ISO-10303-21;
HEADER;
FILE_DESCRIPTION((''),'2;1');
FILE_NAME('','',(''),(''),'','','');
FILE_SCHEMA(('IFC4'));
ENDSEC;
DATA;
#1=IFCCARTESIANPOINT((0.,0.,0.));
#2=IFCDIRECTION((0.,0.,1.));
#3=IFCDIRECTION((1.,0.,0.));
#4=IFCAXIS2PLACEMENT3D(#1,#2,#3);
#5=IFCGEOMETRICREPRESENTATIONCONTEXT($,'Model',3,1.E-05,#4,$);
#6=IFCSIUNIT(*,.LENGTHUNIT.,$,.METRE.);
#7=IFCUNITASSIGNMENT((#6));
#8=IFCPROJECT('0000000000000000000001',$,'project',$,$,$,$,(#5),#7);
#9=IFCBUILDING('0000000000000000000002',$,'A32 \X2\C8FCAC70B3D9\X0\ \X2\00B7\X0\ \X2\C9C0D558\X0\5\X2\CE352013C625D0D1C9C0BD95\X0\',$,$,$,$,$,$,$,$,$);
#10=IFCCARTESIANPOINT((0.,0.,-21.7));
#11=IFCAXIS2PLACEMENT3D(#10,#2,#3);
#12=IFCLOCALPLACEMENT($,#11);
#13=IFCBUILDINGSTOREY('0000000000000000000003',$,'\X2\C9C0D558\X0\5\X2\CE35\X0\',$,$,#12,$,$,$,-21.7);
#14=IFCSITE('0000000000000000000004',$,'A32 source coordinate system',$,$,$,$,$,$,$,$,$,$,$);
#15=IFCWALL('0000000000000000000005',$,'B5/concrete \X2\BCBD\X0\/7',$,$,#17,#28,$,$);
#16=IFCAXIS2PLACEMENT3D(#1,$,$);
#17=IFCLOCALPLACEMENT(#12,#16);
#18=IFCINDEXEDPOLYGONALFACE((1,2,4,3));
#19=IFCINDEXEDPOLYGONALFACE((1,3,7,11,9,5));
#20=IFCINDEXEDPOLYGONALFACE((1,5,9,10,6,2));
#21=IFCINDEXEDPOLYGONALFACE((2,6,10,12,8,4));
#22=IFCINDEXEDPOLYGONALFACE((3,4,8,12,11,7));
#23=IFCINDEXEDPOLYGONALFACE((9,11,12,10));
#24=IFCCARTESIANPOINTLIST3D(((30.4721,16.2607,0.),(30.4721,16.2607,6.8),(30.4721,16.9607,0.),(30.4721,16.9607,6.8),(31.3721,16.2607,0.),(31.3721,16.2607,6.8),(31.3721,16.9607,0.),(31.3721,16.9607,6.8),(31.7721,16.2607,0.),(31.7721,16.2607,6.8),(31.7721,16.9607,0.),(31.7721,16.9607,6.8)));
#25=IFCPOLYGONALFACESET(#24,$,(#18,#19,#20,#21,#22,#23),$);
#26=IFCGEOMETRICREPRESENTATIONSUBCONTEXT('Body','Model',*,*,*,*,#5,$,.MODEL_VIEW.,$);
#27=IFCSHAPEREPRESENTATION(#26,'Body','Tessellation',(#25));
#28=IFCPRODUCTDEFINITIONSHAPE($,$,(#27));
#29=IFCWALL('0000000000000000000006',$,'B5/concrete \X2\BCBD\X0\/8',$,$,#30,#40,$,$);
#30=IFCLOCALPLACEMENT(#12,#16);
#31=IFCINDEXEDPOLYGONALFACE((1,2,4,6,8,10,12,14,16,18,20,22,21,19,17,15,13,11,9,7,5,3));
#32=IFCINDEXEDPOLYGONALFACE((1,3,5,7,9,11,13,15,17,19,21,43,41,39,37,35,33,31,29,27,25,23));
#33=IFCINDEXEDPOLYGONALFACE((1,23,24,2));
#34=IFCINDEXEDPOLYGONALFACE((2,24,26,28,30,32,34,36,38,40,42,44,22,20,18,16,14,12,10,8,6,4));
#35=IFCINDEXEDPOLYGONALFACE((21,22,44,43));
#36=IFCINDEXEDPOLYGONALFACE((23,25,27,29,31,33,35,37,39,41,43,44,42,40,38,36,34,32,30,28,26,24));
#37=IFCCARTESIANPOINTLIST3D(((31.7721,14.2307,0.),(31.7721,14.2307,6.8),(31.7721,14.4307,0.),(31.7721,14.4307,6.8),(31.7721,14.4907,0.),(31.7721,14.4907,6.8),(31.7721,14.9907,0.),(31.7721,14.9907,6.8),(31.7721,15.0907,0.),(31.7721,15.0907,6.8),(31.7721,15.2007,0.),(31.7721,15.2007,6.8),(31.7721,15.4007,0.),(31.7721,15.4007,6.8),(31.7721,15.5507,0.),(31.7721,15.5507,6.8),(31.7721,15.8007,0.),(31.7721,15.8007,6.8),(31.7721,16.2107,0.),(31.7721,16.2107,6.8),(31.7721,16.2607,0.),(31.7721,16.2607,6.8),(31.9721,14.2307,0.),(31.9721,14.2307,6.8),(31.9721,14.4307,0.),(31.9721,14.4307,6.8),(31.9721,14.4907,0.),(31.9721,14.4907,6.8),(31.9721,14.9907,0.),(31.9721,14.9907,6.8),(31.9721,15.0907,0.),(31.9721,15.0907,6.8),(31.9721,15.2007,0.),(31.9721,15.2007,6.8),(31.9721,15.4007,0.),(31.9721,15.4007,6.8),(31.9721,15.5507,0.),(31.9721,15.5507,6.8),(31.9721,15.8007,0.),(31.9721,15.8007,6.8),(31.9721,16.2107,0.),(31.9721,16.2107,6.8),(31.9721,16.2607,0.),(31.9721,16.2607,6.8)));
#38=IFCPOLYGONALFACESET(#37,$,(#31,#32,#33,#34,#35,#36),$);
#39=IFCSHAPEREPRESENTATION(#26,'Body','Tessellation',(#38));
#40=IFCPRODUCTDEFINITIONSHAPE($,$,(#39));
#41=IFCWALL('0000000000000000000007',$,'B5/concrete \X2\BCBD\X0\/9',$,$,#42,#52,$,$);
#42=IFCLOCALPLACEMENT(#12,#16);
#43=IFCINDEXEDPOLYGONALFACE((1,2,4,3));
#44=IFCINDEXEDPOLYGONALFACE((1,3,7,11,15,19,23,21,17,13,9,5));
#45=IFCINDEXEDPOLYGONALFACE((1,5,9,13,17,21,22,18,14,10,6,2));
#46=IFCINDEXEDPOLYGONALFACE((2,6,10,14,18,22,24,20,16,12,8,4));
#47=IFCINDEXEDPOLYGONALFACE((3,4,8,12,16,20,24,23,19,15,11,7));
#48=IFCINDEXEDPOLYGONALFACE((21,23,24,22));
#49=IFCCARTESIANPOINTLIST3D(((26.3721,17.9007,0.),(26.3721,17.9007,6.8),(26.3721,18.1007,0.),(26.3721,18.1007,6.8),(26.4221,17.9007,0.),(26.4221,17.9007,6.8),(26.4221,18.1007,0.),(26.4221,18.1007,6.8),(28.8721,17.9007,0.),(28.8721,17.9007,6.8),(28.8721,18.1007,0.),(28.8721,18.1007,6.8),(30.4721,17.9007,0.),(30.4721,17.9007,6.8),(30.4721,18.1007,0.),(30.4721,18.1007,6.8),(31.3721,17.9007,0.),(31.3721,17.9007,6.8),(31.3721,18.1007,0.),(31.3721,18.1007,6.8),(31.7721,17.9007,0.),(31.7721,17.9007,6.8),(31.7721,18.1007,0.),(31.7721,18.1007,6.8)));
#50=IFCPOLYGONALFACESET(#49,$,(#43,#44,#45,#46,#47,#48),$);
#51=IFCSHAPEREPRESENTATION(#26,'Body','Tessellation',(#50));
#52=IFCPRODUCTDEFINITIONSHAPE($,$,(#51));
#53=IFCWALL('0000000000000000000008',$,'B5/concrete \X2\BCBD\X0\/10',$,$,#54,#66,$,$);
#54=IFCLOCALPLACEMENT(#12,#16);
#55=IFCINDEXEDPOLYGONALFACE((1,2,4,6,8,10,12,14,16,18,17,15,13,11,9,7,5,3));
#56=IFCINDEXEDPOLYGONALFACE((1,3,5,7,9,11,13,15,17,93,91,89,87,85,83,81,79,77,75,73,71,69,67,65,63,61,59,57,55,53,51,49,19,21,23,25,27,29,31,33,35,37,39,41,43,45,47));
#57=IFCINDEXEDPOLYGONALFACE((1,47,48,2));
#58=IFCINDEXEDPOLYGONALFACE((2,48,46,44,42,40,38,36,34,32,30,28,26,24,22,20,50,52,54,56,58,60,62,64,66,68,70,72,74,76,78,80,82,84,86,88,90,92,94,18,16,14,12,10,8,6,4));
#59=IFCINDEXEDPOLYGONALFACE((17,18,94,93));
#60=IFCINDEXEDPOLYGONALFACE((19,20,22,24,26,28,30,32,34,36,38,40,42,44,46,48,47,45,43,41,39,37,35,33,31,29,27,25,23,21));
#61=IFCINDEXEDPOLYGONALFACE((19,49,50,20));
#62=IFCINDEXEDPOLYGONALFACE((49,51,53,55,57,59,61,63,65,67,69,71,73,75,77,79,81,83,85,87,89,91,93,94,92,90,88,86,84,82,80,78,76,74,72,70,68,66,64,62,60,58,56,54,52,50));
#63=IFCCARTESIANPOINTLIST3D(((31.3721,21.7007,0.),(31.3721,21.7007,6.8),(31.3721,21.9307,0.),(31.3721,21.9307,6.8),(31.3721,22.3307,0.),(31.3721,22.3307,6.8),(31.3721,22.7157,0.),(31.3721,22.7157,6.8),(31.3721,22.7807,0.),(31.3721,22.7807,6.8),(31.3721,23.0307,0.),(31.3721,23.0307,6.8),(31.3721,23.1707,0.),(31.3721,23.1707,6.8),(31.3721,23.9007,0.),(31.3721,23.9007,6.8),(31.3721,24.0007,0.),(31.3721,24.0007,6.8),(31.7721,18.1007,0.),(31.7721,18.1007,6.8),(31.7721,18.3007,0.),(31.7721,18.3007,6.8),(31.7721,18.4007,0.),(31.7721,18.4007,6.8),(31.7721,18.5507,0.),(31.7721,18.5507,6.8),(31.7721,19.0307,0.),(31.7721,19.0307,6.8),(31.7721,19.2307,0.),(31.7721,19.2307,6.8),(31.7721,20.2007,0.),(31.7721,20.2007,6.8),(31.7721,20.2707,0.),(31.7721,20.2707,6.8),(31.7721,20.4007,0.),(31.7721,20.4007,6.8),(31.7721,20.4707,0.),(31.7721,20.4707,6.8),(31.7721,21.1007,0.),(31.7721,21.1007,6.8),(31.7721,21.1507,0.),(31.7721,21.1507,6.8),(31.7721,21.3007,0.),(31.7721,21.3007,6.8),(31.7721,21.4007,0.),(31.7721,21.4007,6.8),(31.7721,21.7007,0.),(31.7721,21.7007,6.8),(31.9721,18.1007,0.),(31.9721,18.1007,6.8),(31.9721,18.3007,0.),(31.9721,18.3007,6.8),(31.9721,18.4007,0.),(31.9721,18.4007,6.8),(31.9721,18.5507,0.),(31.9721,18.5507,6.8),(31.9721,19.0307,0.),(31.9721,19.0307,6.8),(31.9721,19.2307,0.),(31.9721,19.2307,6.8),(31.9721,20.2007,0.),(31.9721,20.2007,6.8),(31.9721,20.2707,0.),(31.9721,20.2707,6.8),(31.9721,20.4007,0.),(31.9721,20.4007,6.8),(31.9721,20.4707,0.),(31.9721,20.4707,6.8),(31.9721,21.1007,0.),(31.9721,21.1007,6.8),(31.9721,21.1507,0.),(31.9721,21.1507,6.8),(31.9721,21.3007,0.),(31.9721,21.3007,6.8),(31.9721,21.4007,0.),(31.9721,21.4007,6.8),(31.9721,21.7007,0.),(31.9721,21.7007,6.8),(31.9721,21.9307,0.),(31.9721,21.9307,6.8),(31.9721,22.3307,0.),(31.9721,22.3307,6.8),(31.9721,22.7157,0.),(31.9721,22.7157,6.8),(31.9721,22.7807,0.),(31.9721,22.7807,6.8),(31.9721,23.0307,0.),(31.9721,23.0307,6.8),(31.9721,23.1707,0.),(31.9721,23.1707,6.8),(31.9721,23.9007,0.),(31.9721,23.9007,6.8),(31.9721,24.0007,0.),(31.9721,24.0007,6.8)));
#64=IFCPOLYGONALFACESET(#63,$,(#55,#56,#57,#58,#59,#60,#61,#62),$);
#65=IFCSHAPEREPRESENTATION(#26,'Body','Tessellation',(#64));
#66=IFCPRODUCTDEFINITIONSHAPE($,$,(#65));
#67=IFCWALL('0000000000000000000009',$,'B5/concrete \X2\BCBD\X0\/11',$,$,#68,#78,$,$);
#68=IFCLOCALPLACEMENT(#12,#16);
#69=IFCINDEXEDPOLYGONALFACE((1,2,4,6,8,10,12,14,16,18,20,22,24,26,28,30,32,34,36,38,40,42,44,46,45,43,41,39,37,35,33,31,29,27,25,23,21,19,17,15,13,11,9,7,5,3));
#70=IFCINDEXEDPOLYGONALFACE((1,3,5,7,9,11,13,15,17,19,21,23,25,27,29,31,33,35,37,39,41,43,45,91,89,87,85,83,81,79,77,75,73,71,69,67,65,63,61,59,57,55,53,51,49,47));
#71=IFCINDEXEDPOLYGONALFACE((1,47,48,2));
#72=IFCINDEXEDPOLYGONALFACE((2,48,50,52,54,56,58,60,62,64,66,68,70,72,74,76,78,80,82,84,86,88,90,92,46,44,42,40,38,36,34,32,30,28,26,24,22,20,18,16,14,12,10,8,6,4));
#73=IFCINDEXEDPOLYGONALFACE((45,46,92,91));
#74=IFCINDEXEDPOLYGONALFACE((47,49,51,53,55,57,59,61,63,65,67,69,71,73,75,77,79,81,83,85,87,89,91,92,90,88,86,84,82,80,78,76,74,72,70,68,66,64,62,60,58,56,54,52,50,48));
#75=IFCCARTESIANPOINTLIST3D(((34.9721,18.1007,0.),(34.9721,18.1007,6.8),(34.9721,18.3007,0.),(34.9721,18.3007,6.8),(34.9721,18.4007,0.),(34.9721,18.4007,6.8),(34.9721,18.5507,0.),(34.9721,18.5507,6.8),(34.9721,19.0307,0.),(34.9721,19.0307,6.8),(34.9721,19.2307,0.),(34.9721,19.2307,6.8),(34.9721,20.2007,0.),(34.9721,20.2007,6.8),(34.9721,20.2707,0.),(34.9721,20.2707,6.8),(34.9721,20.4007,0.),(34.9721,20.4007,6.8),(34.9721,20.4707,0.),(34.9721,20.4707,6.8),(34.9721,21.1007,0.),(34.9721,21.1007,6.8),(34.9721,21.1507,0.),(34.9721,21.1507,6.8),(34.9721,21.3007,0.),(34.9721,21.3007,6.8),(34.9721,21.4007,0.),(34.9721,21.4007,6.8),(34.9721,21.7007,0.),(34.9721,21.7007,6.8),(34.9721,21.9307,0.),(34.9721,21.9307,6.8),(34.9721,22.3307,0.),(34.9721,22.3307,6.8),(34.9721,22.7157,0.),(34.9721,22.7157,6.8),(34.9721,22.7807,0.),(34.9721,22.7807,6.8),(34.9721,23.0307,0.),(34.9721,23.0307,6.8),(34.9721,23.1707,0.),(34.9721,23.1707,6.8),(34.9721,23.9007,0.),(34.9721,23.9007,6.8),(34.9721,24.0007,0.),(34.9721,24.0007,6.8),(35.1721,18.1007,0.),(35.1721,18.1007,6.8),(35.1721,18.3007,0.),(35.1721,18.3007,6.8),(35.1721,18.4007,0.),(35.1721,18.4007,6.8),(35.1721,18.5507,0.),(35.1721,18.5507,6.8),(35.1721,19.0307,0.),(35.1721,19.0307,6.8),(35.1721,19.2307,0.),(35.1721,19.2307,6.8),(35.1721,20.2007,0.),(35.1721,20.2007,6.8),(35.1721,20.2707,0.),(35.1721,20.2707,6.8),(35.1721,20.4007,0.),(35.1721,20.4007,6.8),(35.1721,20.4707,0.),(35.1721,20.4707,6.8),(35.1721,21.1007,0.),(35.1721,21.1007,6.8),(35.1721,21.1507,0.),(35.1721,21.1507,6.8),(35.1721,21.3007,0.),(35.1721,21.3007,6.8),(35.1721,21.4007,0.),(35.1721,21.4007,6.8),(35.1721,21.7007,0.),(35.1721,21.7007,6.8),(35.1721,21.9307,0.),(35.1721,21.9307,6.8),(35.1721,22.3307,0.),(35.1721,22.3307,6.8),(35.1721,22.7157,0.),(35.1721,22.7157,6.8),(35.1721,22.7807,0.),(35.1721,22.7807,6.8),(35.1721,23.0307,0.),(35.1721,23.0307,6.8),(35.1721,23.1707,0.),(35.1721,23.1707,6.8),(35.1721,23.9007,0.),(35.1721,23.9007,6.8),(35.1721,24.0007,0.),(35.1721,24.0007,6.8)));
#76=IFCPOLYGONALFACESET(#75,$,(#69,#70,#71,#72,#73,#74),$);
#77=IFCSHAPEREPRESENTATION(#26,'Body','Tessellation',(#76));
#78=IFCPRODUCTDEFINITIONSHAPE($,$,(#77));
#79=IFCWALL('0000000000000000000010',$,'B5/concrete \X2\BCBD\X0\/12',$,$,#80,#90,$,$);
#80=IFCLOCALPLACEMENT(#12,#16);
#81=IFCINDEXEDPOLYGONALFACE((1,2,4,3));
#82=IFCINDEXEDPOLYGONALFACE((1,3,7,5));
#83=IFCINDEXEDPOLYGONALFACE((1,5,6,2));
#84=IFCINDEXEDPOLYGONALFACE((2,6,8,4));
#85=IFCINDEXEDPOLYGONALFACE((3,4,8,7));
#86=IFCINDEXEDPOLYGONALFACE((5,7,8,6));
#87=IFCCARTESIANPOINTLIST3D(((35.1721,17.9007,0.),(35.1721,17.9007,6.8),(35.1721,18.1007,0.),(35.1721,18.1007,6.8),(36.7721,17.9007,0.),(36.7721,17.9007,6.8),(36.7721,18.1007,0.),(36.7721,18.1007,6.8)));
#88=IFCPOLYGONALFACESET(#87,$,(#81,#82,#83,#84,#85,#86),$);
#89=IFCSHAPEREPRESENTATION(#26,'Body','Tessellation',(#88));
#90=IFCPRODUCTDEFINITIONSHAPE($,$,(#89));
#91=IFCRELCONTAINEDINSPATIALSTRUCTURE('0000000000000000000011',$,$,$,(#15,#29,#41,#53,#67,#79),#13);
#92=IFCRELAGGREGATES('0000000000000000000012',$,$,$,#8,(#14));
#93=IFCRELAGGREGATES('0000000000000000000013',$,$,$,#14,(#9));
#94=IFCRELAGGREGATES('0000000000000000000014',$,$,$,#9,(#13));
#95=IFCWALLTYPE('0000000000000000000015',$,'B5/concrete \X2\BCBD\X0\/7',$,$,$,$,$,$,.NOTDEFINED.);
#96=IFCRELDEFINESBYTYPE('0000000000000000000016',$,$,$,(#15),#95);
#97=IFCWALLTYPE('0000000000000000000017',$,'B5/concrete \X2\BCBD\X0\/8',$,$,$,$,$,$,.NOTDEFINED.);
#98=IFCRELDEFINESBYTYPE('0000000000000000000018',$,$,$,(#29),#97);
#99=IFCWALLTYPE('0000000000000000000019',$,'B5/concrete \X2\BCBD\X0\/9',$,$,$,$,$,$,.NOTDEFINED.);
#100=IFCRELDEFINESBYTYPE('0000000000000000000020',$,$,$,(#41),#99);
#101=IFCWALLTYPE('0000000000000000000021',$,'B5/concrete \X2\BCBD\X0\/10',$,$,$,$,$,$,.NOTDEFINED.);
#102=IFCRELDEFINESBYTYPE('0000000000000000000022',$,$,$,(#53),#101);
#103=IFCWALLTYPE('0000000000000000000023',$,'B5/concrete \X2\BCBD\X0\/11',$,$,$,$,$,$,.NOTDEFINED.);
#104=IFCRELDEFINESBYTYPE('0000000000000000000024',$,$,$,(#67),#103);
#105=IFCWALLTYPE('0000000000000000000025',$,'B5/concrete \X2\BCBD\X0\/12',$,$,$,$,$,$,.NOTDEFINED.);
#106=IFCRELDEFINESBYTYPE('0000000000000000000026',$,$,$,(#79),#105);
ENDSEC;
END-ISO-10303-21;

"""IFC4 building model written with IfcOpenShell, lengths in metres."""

from ifc_helpers import new_model, si_unit, frame, origin, origin_with_axes, place, context, subcontext, project, spatial, polyline, outline, extrude, source, transform, mapped, type_object, type_shapes, element, save


model = new_model("IFC4")

# Units and contexts
model_context = context("Model", 3, precision=1e-05, world=origin_with_axes())
body_context = subcontext(model_context, "Body", "Model", "MODEL_VIEW")
ifc_project = project(units=[si_unit("LENGTHUNIT", "METRE")], contexts=[model_context])

# Site, building, storey
site = spatial("IfcSite", under=ifc_project, Name="A32 source coordinate system")
building = spatial("IfcBuilding", under=site, Name="A32 주거동 · 지하5층–옥탑지붕")
storey_placement = place(None, frame((0.0, 0.0, -21.7), z_axis=(0.0, 0.0, 1.0), x_axis=(1.0, 0.0, 0.0)))
storey = spatial("IfcBuildingStorey", under=building, at=storey_placement, Name="지하5층", Elevation=-21.7)

# Walls
wall_type_1 = type_object("IfcWallType", Name="B5/concrete 벽/7", PredefinedType="NOTDEFINED")
shared_shape_1 = source(origin(), body_context, "Body", "SweptSolid", [
    extrude(outline(polyline([(30.4721, 16.2607), (30.4721, 16.9607), (31.3721, 16.9607), (31.7721, 16.9607), (31.7721, 16.2607), (31.3721, 16.2607), (30.4721, 16.2607)])), origin(), (0.0, 0.0, 1.0), 6.8),
])
type_shapes(wall_type_1, [shared_shape_1])
wall_1_placement = place(storey_placement, origin_with_axes())
element("IfcWall", 1, at=wall_1_placement, inside=storey, type_object=wall_type_1, Name="B5/concrete 벽/7", context=body_context, shape_type="MappedRepresentation", body=[
    mapped(shared_shape_1, transform((0.0, 0.0, 0.0), scale=1.0)),
])
wall_type_2 = type_object("IfcWallType", Name="B5/concrete 벽/8", PredefinedType="NOTDEFINED")
shared_shape_2 = source(origin(), body_context, "Body", "SweptSolid", [
    extrude(outline(polyline([(31.9721, 15.8007), (31.9721, 15.5507), (31.9721, 15.4007), (31.9721, 15.2007), (31.9721, 15.0907), (31.9721, 14.9907), (31.9721, 14.4907), (31.9721, 14.4307), (31.9721, 14.2307), (31.7721, 14.2307), (31.7721, 14.4307), (31.7721, 14.4907), (31.7721, 14.9907), (31.7721, 15.0907), (31.7721, 15.2007), (31.7721, 15.4007), (31.7721, 15.5507), (31.7721, 15.8007), (31.7721, 16.2107), (31.7721, 16.2607), (31.9721, 16.2607), (31.9721, 16.2107), (31.9721, 15.8007)])), origin(), (0.0, 0.0, 1.0), 6.8),
])
type_shapes(wall_type_2, [shared_shape_2])
wall_2_placement = place(storey_placement, origin_with_axes())
element("IfcWall", 2, at=wall_2_placement, inside=storey, type_object=wall_type_2, Name="B5/concrete 벽/8", context=body_context, shape_type="MappedRepresentation", body=[
    mapped(shared_shape_2, transform((0.0, 0.0, 0.0), scale=1.0)),
])
wall_type_3 = type_object("IfcWallType", Name="B5/concrete 벽/9", PredefinedType="NOTDEFINED")
shared_shape_3 = source(origin(), body_context, "Body", "SweptSolid", [
    extrude(outline(polyline([(28.8721, 17.9007), (26.4221, 17.9007), (26.3721, 17.9007), (26.3721, 18.1007), (26.4221, 18.1007), (28.8721, 18.1007), (30.4721, 18.1007), (31.3721, 18.1007), (31.7721, 18.1007), (31.7721, 17.9007), (31.3721, 17.9007), (30.4721, 17.9007), (28.8721, 17.9007)])), origin(), (0.0, 0.0, 1.0), 6.8),
])
type_shapes(wall_type_3, [shared_shape_3])
wall_3_placement = place(storey_placement, origin_with_axes())
element("IfcWall", 3, at=wall_3_placement, inside=storey, type_object=wall_type_3, Name="B5/concrete 벽/9", context=body_context, shape_type="MappedRepresentation", body=[
    mapped(shared_shape_3, transform((0.0, 0.0, 0.0), scale=1.0)),
])
wall_type_4 = type_object("IfcWallType", Name="B5/concrete 벽/10", PredefinedType="NOTDEFINED")
shared_shape_4 = source(origin(), body_context, "Body", "SweptSolid", [
    extrude(outline(polyline([(31.7721, 18.5507), (31.7721, 19.0307), (31.7721, 19.2307), (31.7721, 20.2007), (31.7721, 20.2707), (31.7721, 20.4007), (31.7721, 20.4707), (31.7721, 21.1007), (31.7721, 21.1507), (31.7721, 21.3007), (31.7721, 21.4007), (31.7721, 21.7007), (31.3721, 21.7007), (31.3721, 21.9307), (31.3721, 22.3307), (31.3721, 22.7157), (31.3721, 22.7807), (31.3721, 23.0307), (31.3721, 23.1707), (31.3721, 23.9007), (31.3721, 24.0007), (31.9721, 24.0007), (31.9721, 23.9007), (31.9721, 23.1707), (31.9721, 23.0307), (31.9721, 22.7807), (31.9721, 22.7157), (31.9721, 22.3307), (31.9721, 21.9307), (31.9721, 21.7007), (31.9721, 21.4007), (31.9721, 21.3007), (31.9721, 21.1507), (31.9721, 21.1007), (31.9721, 20.4707), (31.9721, 20.4007), (31.9721, 20.2707), (31.9721, 20.2007), (31.9721, 19.2307), (31.9721, 19.0307), (31.9721, 18.5507), (31.9721, 18.4007), (31.9721, 18.3007), (31.9721, 18.1007), (31.7721, 18.1007), (31.7721, 18.3007), (31.7721, 18.4007), (31.7721, 18.5507)])), origin(), (0.0, 0.0, 1.0), 6.8),
])
type_shapes(wall_type_4, [shared_shape_4])
wall_4_placement = place(storey_placement, origin_with_axes())
element("IfcWall", 4, at=wall_4_placement, inside=storey, type_object=wall_type_4, Name="B5/concrete 벽/10", context=body_context, shape_type="MappedRepresentation", body=[
    mapped(shared_shape_4, transform((0.0, 0.0, 0.0), scale=1.0)),
])
wall_type_5 = type_object("IfcWallType", Name="B5/concrete 벽/11", PredefinedType="NOTDEFINED")
shared_shape_5 = source(origin(), body_context, "Body", "SweptSolid", [
    extrude(outline(polyline([(34.9721, 18.5507), (34.9721, 19.0307), (34.9721, 19.2307), (34.9721, 20.2007), (34.9721, 20.2707), (34.9721, 20.4007), (34.9721, 20.4707), (34.9721, 21.1007), (34.9721, 21.1507), (34.9721, 21.3007), (34.9721, 21.4007), (34.9721, 21.7007), (34.9721, 21.9307), (34.9721, 22.3307), (34.9721, 22.7157), (34.9721, 22.7807), (34.9721, 23.0307), (34.9721, 23.1707), (34.9721, 23.9007), (34.9721, 24.0007), (35.1721, 24.0007), (35.1721, 23.9007), (35.1721, 23.1707), (35.1721, 23.0307), (35.1721, 22.7807), (35.1721, 22.7157), (35.1721, 22.3307), (35.1721, 21.9307), (35.1721, 21.7007), (35.1721, 21.4007), (35.1721, 21.3007), (35.1721, 21.1507), (35.1721, 21.1007), (35.1721, 20.4707), (35.1721, 20.4007), (35.1721, 20.2707), (35.1721, 20.2007), (35.1721, 19.2307), (35.1721, 19.0307), (35.1721, 18.5507), (35.1721, 18.4007), (35.1721, 18.3007), (35.1721, 18.1007), (34.9721, 18.1007), (34.9721, 18.3007), (34.9721, 18.4007), (34.9721, 18.5507)])), origin(), (0.0, 0.0, 1.0), 6.8),
])
type_shapes(wall_type_5, [shared_shape_5])
wall_5_placement = place(storey_placement, origin_with_axes())
element("IfcWall", 5, at=wall_5_placement, inside=storey, type_object=wall_type_5, Name="B5/concrete 벽/11", context=body_context, shape_type="MappedRepresentation", body=[
    mapped(shared_shape_5, transform((0.0, 0.0, 0.0), scale=1.0)),
])
wall_type_6 = type_object("IfcWallType", Name="B5/concrete 벽/12", PredefinedType="NOTDEFINED")
shared_shape_6 = source(origin(), body_context, "Body", "SweptSolid", [
    extrude(outline(polyline([(35.1721, 17.9007), (35.1721, 18.1007), (36.7721, 18.1007), (36.7721, 17.9007), (35.1721, 17.9007)])), origin(), (0.0, 0.0, 1.0), 6.8),
])
type_shapes(wall_type_6, [shared_shape_6])
wall_6_placement = place(storey_placement, origin_with_axes())
element("IfcWall", 6, at=wall_6_placement, inside=storey, type_object=wall_type_6, Name="B5/concrete 벽/12", context=body_context, shape_type="MappedRepresentation", body=[
    mapped(shared_shape_6, transform((0.0, 0.0, 0.0), scale=1.0)),
])

save(model, "model.ifc")
